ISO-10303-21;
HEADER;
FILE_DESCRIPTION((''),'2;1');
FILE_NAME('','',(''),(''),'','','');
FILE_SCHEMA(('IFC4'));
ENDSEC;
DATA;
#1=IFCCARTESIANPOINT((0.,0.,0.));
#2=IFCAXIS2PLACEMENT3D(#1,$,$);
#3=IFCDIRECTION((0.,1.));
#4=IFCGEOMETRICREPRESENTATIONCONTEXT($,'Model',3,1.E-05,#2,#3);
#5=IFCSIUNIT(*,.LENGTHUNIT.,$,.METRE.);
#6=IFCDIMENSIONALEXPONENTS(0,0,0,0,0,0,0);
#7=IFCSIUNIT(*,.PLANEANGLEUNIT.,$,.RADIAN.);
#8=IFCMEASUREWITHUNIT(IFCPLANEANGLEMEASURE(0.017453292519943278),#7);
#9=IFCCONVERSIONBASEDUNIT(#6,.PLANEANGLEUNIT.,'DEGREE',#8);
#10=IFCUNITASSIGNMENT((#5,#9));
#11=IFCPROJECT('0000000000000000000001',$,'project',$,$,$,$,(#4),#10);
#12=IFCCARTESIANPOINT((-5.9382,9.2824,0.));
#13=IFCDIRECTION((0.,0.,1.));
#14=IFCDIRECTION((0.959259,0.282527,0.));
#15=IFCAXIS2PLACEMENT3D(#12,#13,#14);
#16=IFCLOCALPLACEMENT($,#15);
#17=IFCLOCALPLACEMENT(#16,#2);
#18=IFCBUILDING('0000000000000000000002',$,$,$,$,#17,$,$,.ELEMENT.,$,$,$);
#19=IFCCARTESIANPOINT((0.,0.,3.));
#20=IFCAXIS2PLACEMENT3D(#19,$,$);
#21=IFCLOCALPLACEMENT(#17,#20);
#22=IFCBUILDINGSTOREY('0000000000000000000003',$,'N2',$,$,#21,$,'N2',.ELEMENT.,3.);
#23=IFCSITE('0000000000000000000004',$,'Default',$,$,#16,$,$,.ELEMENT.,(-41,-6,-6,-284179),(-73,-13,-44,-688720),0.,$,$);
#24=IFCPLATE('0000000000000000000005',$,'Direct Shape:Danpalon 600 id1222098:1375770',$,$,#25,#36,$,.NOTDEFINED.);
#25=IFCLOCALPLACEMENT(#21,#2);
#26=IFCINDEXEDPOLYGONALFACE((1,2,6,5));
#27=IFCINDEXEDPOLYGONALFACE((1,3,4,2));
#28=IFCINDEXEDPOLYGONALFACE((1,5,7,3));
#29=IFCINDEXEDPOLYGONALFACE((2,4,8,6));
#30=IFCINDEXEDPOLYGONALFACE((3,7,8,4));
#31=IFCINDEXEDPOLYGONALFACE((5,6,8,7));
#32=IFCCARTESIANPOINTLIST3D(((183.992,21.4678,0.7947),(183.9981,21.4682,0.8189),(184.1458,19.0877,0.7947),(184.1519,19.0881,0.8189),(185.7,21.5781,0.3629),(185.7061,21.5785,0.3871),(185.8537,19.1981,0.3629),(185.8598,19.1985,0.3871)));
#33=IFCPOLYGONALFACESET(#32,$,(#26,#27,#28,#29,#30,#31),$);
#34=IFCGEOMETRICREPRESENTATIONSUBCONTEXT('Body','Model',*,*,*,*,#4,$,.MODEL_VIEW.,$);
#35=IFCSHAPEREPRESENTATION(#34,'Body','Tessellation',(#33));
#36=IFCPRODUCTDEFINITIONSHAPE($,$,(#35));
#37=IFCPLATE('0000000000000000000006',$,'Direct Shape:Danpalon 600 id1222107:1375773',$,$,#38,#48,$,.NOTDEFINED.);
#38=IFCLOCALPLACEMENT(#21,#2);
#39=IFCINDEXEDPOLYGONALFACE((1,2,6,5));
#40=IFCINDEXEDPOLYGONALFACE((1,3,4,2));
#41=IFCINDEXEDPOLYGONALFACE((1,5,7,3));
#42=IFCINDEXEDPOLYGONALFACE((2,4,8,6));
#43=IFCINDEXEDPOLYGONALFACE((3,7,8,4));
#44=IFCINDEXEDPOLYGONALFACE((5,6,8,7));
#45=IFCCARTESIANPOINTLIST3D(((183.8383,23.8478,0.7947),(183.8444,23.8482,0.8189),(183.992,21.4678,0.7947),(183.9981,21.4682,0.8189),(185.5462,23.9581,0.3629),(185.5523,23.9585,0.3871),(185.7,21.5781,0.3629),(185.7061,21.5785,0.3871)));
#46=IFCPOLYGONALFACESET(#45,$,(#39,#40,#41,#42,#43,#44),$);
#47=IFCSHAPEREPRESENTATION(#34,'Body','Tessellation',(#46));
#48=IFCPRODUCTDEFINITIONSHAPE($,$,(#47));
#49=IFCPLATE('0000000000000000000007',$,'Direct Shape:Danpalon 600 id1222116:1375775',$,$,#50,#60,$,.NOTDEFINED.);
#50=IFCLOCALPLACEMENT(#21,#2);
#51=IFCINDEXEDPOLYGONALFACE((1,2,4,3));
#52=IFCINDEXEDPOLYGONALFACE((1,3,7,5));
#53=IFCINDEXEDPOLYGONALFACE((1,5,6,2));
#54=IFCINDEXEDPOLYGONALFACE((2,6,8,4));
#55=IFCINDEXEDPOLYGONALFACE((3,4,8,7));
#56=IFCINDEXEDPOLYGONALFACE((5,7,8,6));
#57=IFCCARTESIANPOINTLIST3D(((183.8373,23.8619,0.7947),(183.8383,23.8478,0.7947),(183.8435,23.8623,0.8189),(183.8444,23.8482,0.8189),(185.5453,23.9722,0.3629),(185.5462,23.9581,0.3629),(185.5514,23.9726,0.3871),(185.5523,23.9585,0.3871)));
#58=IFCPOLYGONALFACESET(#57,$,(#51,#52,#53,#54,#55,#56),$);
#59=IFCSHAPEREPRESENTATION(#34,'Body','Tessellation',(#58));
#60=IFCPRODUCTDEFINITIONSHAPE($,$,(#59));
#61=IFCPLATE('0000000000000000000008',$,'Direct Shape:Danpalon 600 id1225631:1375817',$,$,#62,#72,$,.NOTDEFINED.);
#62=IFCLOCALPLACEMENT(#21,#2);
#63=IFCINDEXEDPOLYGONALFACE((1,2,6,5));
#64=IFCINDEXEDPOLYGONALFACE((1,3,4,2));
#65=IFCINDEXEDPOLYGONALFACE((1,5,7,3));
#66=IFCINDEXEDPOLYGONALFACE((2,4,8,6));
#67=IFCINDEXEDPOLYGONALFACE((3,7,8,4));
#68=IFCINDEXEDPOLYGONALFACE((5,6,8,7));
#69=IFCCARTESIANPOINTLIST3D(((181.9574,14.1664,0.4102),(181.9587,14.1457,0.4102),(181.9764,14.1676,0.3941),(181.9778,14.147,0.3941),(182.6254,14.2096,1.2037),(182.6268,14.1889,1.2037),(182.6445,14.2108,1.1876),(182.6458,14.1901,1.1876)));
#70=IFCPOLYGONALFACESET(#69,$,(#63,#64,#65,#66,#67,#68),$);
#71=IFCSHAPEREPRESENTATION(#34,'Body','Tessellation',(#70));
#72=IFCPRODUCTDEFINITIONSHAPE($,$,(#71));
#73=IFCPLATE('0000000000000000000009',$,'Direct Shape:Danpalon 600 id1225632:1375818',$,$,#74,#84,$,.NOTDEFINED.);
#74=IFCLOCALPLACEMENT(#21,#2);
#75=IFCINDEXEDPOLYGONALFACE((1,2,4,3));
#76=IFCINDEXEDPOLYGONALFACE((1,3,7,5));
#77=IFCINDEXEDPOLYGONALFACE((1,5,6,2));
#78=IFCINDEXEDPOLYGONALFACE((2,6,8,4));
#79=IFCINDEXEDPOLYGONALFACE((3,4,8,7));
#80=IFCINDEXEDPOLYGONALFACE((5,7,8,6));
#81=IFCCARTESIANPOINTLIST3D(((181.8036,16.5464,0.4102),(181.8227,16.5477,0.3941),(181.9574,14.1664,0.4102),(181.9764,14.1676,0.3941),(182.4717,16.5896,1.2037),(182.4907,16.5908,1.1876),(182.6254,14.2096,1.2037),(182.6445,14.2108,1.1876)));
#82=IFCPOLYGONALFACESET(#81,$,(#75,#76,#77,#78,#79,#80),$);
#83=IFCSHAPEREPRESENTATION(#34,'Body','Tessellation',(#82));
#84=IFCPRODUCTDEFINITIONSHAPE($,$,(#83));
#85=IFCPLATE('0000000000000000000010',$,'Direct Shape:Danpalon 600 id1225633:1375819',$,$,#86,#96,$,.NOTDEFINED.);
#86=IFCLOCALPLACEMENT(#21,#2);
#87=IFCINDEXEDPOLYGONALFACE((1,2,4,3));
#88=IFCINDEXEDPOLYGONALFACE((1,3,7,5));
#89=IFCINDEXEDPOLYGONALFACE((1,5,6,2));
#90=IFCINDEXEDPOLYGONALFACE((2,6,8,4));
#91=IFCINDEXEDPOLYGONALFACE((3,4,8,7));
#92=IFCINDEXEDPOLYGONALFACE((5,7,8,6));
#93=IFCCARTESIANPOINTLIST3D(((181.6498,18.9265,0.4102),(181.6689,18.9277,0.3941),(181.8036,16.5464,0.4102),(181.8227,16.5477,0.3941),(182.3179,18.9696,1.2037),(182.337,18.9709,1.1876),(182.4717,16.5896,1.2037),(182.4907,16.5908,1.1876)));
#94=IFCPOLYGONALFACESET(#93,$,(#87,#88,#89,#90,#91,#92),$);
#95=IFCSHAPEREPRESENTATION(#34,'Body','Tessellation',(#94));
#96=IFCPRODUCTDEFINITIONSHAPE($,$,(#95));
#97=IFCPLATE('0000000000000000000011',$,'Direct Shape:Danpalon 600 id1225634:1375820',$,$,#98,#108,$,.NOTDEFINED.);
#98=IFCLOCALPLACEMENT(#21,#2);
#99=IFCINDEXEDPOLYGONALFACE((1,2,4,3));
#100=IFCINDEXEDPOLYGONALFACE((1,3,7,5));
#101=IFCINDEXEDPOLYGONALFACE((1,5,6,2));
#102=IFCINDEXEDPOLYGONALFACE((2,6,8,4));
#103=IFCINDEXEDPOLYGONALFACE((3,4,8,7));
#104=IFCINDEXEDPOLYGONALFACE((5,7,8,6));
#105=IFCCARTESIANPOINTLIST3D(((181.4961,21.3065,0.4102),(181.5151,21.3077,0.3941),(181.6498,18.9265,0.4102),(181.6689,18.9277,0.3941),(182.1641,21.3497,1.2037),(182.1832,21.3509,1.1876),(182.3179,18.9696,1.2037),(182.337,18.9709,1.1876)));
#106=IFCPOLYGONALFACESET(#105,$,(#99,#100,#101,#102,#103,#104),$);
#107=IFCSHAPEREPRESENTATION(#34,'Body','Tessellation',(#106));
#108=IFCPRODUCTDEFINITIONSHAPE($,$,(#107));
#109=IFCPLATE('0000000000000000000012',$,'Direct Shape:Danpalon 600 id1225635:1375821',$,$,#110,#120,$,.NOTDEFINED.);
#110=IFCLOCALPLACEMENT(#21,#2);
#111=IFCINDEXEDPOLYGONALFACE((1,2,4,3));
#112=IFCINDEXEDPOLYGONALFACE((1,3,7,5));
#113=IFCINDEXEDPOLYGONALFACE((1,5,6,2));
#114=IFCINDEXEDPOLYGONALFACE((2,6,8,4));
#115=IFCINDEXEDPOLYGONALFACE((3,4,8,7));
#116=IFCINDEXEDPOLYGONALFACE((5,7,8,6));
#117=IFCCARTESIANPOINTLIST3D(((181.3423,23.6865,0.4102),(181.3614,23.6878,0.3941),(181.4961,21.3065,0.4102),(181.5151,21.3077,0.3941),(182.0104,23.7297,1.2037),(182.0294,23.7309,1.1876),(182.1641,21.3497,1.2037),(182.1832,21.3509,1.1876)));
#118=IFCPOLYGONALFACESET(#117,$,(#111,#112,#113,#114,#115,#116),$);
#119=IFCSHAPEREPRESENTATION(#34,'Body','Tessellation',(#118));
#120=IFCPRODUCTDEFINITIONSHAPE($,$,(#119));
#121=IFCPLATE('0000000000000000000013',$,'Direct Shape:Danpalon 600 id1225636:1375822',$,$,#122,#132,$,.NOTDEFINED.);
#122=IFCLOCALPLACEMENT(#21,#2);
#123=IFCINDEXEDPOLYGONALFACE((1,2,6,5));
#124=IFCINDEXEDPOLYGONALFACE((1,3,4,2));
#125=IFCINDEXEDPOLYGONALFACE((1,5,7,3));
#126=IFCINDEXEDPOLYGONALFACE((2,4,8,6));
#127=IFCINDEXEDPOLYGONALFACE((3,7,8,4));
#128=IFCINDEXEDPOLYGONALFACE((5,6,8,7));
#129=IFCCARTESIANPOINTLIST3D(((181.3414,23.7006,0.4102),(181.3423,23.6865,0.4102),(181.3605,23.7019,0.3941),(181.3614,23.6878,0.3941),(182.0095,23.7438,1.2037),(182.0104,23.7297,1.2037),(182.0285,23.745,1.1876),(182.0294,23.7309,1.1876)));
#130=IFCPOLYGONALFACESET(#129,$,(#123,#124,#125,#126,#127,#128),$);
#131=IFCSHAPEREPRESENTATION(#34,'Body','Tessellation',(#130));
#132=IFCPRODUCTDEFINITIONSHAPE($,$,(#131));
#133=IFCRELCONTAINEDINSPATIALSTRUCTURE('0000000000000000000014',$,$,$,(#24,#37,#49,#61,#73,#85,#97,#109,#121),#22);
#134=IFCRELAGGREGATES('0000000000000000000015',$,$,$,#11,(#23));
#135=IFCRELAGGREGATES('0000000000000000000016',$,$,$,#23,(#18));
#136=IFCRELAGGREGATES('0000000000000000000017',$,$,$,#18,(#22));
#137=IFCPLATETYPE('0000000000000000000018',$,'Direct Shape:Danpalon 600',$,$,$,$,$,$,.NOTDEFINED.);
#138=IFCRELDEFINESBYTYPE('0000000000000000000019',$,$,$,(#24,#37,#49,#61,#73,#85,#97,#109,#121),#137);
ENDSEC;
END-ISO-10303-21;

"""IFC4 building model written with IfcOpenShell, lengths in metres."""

from ifc_helpers import new_model, entity, si_unit, converted_unit, direction, frame, frame_2d, origin, place, context, subcontext, project, spatial, rectangle, extrude, type_object, element, save


model = new_model("IFC4")

# Units and contexts
model_context = context("Model", 3, precision=1e-05, world=origin(), true_north=direction((0.0, 1.0)))
body_context = subcontext(model_context, "Body", "Model", "MODEL_VIEW")
ifc_project = project(units=[si_unit("LENGTHUNIT", "METRE"), converted_unit("PLANEANGLEUNIT", "DEGREE", entity("IfcPlaneAngleMeasure", 0.017453292519943278), si_unit("PLANEANGLEUNIT", "RADIAN"), dimensions=[0, 0, 0, 0, 0, 0, 0])], contexts=[model_context])

# Site, building, storey
site_placement = place(None, frame((-5.9382, 9.2824, 0.0), z_axis=(0.0, 0.0, 1.0), x_axis=(0.959259, 0.282527, 0.0)))
site = spatial("IfcSite", under=ifc_project, at=site_placement, Name="Default", CompositionType="ELEMENT", RefLatitude=(-41, -6, -6, -284179), RefLongitude=(-73, -13, -44, -688720), RefElevation=0.0)
building_placement = place(site_placement, origin())
building = spatial("IfcBuilding", under=site, at=building_placement, CompositionType="ELEMENT")
storey_placement = place(building_placement, frame((0.0, 0.0, 3.0)))
storey = spatial("IfcBuildingStorey", under=building, at=storey_placement, Name="N2", LongName="N2", CompositionType="ELEMENT", Elevation=3.0)

# Plates
plate_type = type_object("IfcPlateType", Name="Direct Shape:Danpalon 600", PredefinedType="NOTDEFINED")
plate_1_placement = place(storey_placement, origin())
element("IfcPlate", 1, at=plate_1_placement, inside=storey, type_object=plate_type, Name="Direct Shape:Danpalon 600 id1222098:1375770", PredefinedType="NOTDEFINED", context=body_context, shape_type="SweptSolid", body=[
    extrude(rectangle(XDim=0.025, YDim=1.7652, at=frame_2d((0.0, 0.0), x_axis=(1.0, 0.0))), frame((185.0028, 19.1431, 0.5909), z_axis=(-0.064471, 0.99792, 0.0), x_axis=(0.24414, 0.015773, 0.969612)), (0.0, 0.0, 1.0), 2.385),
])
plate_2_placement = place(storey_placement, origin())
element("IfcPlate", 2, at=plate_2_placement, inside=storey, type_object=plate_type, Name="Direct Shape:Danpalon 600 id1222107:1375773", PredefinedType="NOTDEFINED", context=body_context, shape_type="SweptSolid", body=[
    extrude(rectangle(XDim=0.025, YDim=1.7652, at=frame_2d((0.0, 0.0), x_axis=(1.0, 0.0))), frame((184.8491, 21.5231, 0.5909), z_axis=(-0.064471, 0.99792, 0.0), x_axis=(0.24414, 0.015773, 0.969612)), (0.0, 0.0, 1.0), 2.385),
])
plate_3_placement = place(storey_placement, origin())
element("IfcPlate", 3, at=plate_3_placement, inside=storey, type_object=plate_type, Name="Direct Shape:Danpalon 600 id1222116:1375775", PredefinedType="NOTDEFINED", context=body_context, shape_type="SweptSolid", body=[
    extrude(rectangle(XDim=0.025, YDim=0.0141, at=frame_2d((0.0, 0.0), x_axis=(0.0, 1.0))), frame((183.8409, 23.855, 0.8068), z_axis=(0.967595, 0.062512, -0.244649), x_axis=(0.064471, -0.99792, 0.0)), (0.0, 0.0, 1.0), 1.7652),
])
plate_4_placement = place(storey_placement, origin())
element("IfcPlate", 4, at=plate_4_placement, inside=storey, type_object=plate_type, Name="Direct Shape:Danpalon 600 id1225631:1375817", PredefinedType="NOTDEFINED", context=body_context, shape_type="SweptSolid", body=[
    extrude(rectangle(XDim=0.025, YDim=0.0207, at=frame_2d((0.0, 0.0), x_axis=(0.0, 1.0))), frame((181.9676, 14.1567, 0.4022), z_axis=(0.643515, 0.041575, 0.764304), x_axis=(-0.064471, 0.99792, 0.0)), (0.0, 0.0, 1.0), 1.0381),
])
plate_5_placement = place(storey_placement, origin())
element("IfcPlate", 5, at=plate_5_placement, inside=storey, type_object=plate_type, Name="Direct Shape:Danpalon 600 id1225632:1375818", PredefinedType="NOTDEFINED", context=body_context, shape_type="SweptSolid", body=[
    extrude(rectangle(XDim=1.0381, YDim=0.025, at=frame_2d((0.0, 0.0), x_axis=(0.0, 1.0))), frame((182.3009, 14.1886, 0.7989), z_axis=(-0.064471, 0.99792, 0.0), x_axis=(-0.762714, -0.049276, 0.644857)), (0.0, 0.0, 1.0), 2.385),
])
plate_6_placement = place(storey_placement, origin())
element("IfcPlate", 6, at=plate_6_placement, inside=storey, type_object=plate_type, Name="Direct Shape:Danpalon 600 id1225633:1375819", PredefinedType="NOTDEFINED", context=body_context, shape_type="SweptSolid", body=[
    extrude(rectangle(XDim=1.0381, YDim=0.025, at=frame_2d((0.0, 0.0), x_axis=(0.0, 1.0))), frame((182.1472, 16.5686, 0.7989), z_axis=(-0.064471, 0.99792, 0.0), x_axis=(-0.762714, -0.049276, 0.644857)), (0.0, 0.0, 1.0), 2.385),
])
plate_7_placement = place(storey_placement, origin())
element("IfcPlate", 7, at=plate_7_placement, inside=storey, type_object=plate_type, Name="Direct Shape:Danpalon 600 id1225634:1375820", PredefinedType="NOTDEFINED", context=body_context, shape_type="SweptSolid", body=[
    extrude(rectangle(XDim=1.0381, YDim=0.025, at=frame_2d((0.0, 0.0), x_axis=(0.0, 1.0))), frame((181.9934, 18.9487, 0.7989), z_axis=(-0.064471, 0.99792, 0.0), x_axis=(-0.762714, -0.049276, 0.644857)), (0.0, 0.0, 1.0), 2.385),
])
plate_8_placement = place(storey_placement, origin())
element("IfcPlate", 8, at=plate_8_placement, inside=storey, type_object=plate_type, Name="Direct Shape:Danpalon 600 id1225635:1375821", PredefinedType="NOTDEFINED", context=body_context, shape_type="SweptSolid", body=[
    extrude(rectangle(XDim=1.0381, YDim=0.025, at=frame_2d((0.0, 0.0), x_axis=(0.0, 1.0))), frame((181.8396, 21.3287, 0.7989), z_axis=(-0.064471, 0.99792, 0.0), x_axis=(-0.762714, -0.049276, 0.644857)), (0.0, 0.0, 1.0), 2.385),
])
plate_9_placement = place(storey_placement, origin())
element("IfcPlate", 9, at=plate_9_placement, inside=storey, type_object=plate_type, Name="Direct Shape:Danpalon 600 id1225636:1375822", PredefinedType="NOTDEFINED", context=body_context, shape_type="SweptSolid", body=[
    extrude(rectangle(XDim=0.025, YDim=0.0141, at=frame_2d((0.0, 0.0), x_axis=(0.0, 1.0))), frame((181.3514, 23.6942, 0.4022), z_axis=(0.643515, 0.041575, 0.764304), x_axis=(0.064471, -0.99792, 0.0)), (0.0, 0.0, 1.0), 1.0381),
])

save(model, "model.ifc")
